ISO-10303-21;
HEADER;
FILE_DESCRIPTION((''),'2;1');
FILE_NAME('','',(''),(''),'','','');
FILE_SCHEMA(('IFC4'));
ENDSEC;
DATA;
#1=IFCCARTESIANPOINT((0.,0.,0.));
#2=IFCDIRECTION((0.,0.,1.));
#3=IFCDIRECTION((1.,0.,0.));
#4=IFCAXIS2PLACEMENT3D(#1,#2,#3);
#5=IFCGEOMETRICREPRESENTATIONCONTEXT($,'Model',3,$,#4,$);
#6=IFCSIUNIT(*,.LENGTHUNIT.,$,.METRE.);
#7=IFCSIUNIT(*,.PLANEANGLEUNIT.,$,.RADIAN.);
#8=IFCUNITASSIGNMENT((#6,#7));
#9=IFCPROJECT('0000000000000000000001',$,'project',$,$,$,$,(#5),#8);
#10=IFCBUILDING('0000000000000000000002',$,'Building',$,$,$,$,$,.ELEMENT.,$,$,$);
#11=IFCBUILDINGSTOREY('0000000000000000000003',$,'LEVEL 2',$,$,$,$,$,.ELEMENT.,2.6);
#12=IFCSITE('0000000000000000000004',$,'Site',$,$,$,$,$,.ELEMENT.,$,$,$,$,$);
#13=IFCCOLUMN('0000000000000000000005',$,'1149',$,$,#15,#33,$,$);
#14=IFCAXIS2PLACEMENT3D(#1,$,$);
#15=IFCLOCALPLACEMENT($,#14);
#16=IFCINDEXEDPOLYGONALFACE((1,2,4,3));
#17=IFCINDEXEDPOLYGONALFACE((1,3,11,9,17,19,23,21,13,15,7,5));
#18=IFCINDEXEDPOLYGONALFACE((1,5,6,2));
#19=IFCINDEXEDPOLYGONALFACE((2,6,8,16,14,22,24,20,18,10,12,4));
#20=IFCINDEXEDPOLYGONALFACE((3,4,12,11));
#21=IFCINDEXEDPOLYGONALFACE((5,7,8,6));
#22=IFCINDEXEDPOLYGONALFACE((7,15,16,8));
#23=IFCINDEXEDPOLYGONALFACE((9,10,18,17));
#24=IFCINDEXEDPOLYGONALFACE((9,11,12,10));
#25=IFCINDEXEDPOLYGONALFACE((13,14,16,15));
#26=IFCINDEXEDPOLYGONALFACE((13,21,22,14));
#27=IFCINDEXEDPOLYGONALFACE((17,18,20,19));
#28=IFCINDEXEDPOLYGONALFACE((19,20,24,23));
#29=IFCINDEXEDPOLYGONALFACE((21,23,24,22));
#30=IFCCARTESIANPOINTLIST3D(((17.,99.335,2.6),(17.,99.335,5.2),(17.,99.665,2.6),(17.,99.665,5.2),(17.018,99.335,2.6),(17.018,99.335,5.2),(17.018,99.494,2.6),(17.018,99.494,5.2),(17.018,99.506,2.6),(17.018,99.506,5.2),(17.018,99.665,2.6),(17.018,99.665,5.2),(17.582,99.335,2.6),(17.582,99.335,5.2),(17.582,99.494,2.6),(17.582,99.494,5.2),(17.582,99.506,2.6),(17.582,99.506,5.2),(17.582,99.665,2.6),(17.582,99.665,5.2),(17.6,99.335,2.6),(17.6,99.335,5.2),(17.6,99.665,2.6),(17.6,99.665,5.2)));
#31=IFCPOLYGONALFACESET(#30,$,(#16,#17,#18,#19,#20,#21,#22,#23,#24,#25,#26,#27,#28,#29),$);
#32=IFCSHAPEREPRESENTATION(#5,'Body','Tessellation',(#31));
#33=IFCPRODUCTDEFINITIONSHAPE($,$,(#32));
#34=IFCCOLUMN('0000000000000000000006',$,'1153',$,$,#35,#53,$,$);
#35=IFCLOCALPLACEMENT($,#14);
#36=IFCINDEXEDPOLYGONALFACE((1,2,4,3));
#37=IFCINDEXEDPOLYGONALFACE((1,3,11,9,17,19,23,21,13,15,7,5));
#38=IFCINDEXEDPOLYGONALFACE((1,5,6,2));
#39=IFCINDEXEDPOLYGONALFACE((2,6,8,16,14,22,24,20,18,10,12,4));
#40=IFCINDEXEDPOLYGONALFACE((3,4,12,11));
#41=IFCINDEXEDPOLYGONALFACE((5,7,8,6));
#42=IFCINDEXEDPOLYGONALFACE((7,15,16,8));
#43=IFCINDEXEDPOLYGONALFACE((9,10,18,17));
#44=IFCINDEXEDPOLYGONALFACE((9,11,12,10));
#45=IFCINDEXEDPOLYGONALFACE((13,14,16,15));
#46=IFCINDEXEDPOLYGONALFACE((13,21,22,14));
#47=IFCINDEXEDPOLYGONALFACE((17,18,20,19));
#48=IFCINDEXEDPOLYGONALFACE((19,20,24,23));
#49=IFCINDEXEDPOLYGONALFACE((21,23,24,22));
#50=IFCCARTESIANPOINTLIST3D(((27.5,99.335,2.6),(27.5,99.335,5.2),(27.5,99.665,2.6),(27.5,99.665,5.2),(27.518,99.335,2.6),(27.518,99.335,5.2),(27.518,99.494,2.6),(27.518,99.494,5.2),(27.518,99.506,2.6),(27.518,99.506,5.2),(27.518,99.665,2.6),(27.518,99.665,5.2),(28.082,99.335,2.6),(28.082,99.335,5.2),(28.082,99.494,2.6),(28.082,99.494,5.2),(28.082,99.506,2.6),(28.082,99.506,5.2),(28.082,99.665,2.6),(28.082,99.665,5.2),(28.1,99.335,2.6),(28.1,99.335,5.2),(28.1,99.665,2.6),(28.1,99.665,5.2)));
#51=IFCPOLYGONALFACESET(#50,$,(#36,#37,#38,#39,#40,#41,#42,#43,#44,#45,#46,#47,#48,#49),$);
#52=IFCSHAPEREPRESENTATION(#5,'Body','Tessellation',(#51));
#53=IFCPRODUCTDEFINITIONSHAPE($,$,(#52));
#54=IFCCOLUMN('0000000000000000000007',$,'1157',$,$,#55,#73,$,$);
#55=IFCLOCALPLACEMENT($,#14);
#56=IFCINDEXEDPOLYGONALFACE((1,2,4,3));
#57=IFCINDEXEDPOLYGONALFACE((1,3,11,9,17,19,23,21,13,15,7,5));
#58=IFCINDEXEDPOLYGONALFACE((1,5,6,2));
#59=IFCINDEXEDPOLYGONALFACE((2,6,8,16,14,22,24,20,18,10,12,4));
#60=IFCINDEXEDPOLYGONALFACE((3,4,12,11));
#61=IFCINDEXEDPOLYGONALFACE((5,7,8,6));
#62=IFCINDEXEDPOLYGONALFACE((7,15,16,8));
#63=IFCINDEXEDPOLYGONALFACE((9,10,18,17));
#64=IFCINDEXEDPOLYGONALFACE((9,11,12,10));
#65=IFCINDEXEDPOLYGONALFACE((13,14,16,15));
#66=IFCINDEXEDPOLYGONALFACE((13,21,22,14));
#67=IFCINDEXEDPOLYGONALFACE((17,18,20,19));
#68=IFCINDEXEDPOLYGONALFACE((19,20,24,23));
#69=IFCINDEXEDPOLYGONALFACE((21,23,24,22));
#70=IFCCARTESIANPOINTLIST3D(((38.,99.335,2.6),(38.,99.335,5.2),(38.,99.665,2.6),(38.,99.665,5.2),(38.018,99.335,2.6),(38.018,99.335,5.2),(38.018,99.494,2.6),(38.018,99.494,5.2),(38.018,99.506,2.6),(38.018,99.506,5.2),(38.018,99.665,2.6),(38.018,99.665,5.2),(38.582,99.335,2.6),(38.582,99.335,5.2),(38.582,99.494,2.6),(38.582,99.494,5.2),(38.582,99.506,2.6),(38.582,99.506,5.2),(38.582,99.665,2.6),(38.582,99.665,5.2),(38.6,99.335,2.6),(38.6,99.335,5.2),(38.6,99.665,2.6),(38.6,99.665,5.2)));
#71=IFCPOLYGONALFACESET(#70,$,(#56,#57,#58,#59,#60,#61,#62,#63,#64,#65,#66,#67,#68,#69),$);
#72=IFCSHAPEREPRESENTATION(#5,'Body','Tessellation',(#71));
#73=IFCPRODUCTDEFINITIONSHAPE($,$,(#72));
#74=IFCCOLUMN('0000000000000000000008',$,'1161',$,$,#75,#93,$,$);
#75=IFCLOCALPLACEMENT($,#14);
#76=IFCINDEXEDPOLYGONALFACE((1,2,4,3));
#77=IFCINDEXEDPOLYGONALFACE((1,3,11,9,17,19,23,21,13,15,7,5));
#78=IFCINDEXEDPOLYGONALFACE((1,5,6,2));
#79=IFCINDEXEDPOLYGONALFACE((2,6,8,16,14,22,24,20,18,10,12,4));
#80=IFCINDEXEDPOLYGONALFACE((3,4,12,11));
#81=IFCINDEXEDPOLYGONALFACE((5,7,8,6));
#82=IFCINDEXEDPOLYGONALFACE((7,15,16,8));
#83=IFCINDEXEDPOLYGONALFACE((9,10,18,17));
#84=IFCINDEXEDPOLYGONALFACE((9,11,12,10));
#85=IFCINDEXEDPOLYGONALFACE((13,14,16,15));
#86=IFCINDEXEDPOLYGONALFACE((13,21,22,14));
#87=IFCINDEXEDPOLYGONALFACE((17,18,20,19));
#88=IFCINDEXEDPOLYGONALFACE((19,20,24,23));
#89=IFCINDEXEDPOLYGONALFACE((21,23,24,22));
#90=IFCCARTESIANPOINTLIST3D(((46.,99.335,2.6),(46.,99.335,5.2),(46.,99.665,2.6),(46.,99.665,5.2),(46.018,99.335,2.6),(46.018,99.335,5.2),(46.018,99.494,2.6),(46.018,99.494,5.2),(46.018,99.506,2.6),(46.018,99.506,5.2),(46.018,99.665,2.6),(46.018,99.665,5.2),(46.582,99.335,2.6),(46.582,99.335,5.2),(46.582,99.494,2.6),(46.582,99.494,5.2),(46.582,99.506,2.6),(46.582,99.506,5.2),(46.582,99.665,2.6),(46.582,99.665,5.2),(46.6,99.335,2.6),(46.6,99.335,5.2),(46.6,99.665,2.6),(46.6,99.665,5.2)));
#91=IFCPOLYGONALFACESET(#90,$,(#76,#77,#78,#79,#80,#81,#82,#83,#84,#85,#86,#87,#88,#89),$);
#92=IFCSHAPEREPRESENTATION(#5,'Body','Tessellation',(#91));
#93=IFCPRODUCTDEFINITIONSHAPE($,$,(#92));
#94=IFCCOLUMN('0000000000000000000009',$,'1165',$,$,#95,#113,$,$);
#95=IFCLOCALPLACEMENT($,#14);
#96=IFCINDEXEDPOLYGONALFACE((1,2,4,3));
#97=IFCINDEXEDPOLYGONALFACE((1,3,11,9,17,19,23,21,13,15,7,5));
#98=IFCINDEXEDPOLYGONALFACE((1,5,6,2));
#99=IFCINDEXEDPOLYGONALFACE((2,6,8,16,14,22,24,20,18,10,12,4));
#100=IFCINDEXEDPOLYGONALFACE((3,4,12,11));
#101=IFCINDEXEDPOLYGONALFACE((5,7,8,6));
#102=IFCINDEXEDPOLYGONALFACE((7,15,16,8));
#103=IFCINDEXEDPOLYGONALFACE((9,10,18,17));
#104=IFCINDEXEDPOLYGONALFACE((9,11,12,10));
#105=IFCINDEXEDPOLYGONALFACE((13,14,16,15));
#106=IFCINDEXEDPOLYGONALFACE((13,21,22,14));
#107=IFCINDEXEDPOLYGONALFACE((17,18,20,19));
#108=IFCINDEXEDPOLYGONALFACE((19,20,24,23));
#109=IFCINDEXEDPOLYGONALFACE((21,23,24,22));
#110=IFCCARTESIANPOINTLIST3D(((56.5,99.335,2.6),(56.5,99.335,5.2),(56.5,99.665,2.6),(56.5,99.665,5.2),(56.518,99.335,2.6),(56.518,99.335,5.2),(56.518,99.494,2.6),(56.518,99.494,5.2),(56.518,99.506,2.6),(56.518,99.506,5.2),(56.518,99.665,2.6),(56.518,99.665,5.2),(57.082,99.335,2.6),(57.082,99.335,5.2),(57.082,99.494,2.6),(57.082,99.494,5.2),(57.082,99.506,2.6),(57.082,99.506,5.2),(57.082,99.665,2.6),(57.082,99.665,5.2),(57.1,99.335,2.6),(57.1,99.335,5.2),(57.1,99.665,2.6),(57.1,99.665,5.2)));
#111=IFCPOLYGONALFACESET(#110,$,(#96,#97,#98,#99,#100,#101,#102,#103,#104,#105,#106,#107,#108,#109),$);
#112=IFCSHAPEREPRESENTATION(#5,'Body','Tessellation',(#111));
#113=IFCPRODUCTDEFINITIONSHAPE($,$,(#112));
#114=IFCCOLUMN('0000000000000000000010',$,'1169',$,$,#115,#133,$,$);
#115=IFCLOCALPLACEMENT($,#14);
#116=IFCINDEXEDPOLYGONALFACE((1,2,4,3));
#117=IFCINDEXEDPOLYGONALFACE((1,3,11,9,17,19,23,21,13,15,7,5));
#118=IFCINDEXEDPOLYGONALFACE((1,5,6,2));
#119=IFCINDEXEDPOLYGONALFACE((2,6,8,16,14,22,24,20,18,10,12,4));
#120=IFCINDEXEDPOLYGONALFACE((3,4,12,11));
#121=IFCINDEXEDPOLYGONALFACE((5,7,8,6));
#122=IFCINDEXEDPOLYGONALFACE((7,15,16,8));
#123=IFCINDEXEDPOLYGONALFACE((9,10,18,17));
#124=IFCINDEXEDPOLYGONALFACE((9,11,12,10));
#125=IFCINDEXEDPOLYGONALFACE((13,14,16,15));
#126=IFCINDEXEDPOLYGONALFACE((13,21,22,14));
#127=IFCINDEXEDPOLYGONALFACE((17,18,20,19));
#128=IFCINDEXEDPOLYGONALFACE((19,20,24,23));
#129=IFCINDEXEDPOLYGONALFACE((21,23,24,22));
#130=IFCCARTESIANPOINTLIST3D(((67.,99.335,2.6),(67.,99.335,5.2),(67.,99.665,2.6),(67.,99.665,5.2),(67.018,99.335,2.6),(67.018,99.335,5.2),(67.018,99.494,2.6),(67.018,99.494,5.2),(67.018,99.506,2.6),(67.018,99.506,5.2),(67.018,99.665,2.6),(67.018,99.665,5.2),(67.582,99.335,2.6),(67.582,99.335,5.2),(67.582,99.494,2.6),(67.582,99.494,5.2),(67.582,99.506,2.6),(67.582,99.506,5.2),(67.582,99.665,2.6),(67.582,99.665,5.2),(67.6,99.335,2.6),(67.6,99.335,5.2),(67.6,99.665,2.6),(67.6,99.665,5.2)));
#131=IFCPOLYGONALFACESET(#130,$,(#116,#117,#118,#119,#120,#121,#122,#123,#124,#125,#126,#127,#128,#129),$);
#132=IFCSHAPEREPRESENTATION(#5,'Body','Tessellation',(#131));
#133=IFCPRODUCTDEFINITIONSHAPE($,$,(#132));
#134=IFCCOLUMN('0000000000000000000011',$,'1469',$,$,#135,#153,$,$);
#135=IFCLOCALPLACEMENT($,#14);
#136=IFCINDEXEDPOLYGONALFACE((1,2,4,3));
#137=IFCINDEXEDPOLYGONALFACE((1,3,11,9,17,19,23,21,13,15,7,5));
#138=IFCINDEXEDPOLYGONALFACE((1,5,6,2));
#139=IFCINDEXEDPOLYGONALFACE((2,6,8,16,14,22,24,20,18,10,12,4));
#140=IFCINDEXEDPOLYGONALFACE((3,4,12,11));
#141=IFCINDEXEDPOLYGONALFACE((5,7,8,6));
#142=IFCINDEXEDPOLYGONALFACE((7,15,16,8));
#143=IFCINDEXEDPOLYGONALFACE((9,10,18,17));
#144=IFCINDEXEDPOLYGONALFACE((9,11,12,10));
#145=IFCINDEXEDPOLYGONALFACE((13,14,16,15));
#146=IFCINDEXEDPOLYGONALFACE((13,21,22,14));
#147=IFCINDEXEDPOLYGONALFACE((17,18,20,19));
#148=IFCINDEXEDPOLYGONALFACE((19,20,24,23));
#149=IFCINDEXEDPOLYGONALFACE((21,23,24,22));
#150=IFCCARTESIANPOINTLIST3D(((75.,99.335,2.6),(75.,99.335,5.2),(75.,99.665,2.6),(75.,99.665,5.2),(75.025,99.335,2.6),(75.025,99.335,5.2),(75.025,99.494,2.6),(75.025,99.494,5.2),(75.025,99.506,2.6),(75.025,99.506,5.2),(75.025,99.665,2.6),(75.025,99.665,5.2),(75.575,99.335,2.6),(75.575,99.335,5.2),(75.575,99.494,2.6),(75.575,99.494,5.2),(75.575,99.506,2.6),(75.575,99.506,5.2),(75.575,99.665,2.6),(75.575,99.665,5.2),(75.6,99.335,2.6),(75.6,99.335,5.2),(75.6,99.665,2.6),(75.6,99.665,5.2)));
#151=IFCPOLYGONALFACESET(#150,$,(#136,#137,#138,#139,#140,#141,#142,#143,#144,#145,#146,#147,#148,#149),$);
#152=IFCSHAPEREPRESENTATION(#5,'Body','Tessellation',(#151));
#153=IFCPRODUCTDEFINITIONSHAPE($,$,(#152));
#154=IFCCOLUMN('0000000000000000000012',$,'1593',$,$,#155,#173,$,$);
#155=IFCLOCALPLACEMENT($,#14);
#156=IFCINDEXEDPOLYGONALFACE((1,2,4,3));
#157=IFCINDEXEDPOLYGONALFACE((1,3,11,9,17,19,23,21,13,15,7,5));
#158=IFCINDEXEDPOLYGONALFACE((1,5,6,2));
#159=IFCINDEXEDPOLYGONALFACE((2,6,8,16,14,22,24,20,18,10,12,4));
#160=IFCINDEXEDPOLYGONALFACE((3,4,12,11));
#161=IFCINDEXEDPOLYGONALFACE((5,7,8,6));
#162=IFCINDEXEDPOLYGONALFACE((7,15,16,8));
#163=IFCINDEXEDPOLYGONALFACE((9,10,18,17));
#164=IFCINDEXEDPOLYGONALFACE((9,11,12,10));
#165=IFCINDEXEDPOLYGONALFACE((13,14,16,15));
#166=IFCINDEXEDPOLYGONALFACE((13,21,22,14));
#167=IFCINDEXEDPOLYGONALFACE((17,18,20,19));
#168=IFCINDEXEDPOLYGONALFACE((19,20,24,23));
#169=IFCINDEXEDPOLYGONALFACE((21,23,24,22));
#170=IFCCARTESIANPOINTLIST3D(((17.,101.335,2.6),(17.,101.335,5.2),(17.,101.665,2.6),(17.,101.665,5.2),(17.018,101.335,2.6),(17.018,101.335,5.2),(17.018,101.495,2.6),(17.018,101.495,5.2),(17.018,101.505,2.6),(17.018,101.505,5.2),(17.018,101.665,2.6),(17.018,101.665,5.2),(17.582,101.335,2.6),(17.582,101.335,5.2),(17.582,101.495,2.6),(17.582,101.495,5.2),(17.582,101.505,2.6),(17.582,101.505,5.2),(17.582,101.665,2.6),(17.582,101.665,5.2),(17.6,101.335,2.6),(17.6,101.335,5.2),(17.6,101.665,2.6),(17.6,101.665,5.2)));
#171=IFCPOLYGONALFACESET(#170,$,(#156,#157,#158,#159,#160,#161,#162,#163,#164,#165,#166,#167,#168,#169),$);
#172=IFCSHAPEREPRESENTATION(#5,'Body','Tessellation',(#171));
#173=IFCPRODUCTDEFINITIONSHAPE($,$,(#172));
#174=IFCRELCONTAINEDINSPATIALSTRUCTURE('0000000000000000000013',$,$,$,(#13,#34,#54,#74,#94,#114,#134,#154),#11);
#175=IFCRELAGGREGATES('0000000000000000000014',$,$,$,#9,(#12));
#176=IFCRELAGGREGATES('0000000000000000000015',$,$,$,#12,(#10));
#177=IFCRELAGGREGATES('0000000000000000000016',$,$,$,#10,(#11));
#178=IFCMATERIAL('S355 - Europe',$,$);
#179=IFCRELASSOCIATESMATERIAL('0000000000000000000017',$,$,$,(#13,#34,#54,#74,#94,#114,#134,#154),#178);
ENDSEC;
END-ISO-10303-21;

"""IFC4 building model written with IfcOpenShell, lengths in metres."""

from ifc_helpers import new_model, si_unit, frame, origin_with_axes, origin_2d_with_axis, place, context, project, spatial, i_section, extrude, material, material_profile, profile_set, profile_usage, element, save


model = new_model("IFC4")

# Units and contexts
model_context = context("Model", 3, world=origin_with_axes())
ifc_project = project(units=[si_unit("LENGTHUNIT", "METRE"), si_unit("PLANEANGLEUNIT", "RADIAN")], contexts=[model_context])

# Site, building, storey
site = spatial("IfcSite", under=ifc_project, Name="Site", CompositionType="ELEMENT")
building = spatial("IfcBuilding", under=site, Name="Building", CompositionType="ELEMENT")
storey = spatial("IfcBuildingStorey", under=building, Name="LEVEL 2", CompositionType="ELEMENT", Elevation=2.6)

# Columns
ifc_material = material(Name="S355 - Europe")
ifc_material_profile_1 = material_profile(ifc_material, i_section(OverallWidth=0.33, OverallDepth=0.6, WebThickness=0.012, FlangeThickness=0.018, at=origin_2d_with_axis()))
ifc_profile_set_1 = profile_set([ifc_material_profile_1])
ifc_profile_usage_1 = profile_usage(ifc_profile_set_1, cardinal=10)
column_1_placement = place(None, frame((17.3, 99.5, 2.6), z_axis=(0.0, 0.0, 1.0), x_axis=(0.0, -1.0, 0.0)))
element("IfcColumn", 1, at=column_1_placement, inside=storey, material=ifc_profile_usage_1, Name="1149", context=model_context, shape_type="SweptSolid", body=[
    extrude(i_section(OverallWidth=0.33, OverallDepth=0.6, WebThickness=0.012, FlangeThickness=0.018, at=origin_2d_with_axis()), origin_with_axes(), (0.0, 0.0, 1.0), 2.6),
])
ifc_material_profile_2 = material_profile(ifc_material, i_section(OverallWidth=0.33, OverallDepth=0.6, WebThickness=0.012, FlangeThickness=0.018, at=origin_2d_with_axis()))
ifc_profile_set_2 = profile_set([ifc_material_profile_2])
ifc_profile_usage_2 = profile_usage(ifc_profile_set_2, cardinal=10)
column_2_placement = place(None, frame((27.8, 99.5, 2.6), z_axis=(0.0, 0.0, 1.0), x_axis=(0.0, -1.0, 0.0)))
element("IfcColumn", 2, at=column_2_placement, inside=storey, material=ifc_profile_usage_2, Name="1153", context=model_context, shape_type="SweptSolid", body=[
    extrude(i_section(OverallWidth=0.33, OverallDepth=0.6, WebThickness=0.012, FlangeThickness=0.018, at=origin_2d_with_axis()), origin_with_axes(), (0.0, 0.0, 1.0), 2.6),
])
ifc_material_profile_3 = material_profile(ifc_material, i_section(OverallWidth=0.33, OverallDepth=0.6, WebThickness=0.012, FlangeThickness=0.018, at=origin_2d_with_axis()))
ifc_profile_set_3 = profile_set([ifc_material_profile_3])
ifc_profile_usage_3 = profile_usage(ifc_profile_set_3, cardinal=10)
column_3_placement = place(None, frame((38.3, 99.5, 2.6), z_axis=(0.0, 0.0, 1.0), x_axis=(0.0, -1.0, 0.0)))
element("IfcColumn", 3, at=column_3_placement, inside=storey, material=ifc_profile_usage_3, Name="1157", context=model_context, shape_type="SweptSolid", body=[
    extrude(i_section(OverallWidth=0.33, OverallDepth=0.6, WebThickness=0.012, FlangeThickness=0.018, at=origin_2d_with_axis()), origin_with_axes(), (0.0, 0.0, 1.0), 2.6),
])
ifc_material_profile_4 = material_profile(ifc_material, i_section(OverallWidth=0.33, OverallDepth=0.6, WebThickness=0.012, FlangeThickness=0.018, at=origin_2d_with_axis()))
ifc_profile_set_4 = profile_set([ifc_material_profile_4])
ifc_profile_usage_4 = profile_usage(ifc_profile_set_4, cardinal=10)
column_4_placement = place(None, frame((46.3, 99.5, 2.6), z_axis=(0.0, 0.0, 1.0), x_axis=(0.0, -1.0, 0.0)))
element("IfcColumn", 4, at=column_4_placement, inside=storey, material=ifc_profile_usage_4, Name="1161", context=model_context, shape_type="SweptSolid", body=[
    extrude(i_section(OverallWidth=0.33, OverallDepth=0.6, WebThickness=0.012, FlangeThickness=0.018, at=origin_2d_with_axis()), origin_with_axes(), (0.0, 0.0, 1.0), 2.6),
])
ifc_material_profile_5 = material_profile(ifc_material, i_section(OverallWidth=0.33, OverallDepth=0.6, WebThickness=0.012, FlangeThickness=0.018, at=origin_2d_with_axis()))
ifc_profile_set_5 = profile_set([ifc_material_profile_5])
ifc_profile_usage_5 = profile_usage(ifc_profile_set_5, cardinal=10)
column_5_placement = place(None, frame((56.8, 99.5, 2.6), z_axis=(0.0, 0.0, 1.0), x_axis=(0.0, -1.0, 0.0)))
element("IfcColumn", 5, at=column_5_placement, inside=storey, material=ifc_profile_usage_5, Name="1165", context=model_context, shape_type="SweptSolid", body=[
    extrude(i_section(OverallWidth=0.33, OverallDepth=0.6, WebThickness=0.012, FlangeThickness=0.018, at=origin_2d_with_axis()), origin_with_axes(), (0.0, 0.0, 1.0), 2.6),
])
ifc_material_profile_6 = material_profile(ifc_material, i_section(OverallWidth=0.33, OverallDepth=0.6, WebThickness=0.012, FlangeThickness=0.018, at=origin_2d_with_axis()))
ifc_profile_set_6 = profile_set([ifc_material_profile_6])
ifc_profile_usage_6 = profile_usage(ifc_profile_set_6, cardinal=10)
column_6_placement = place(None, frame((67.3, 99.5, 2.6), z_axis=(0.0, 0.0, 1.0), x_axis=(0.0, -1.0, 0.0)))
element("IfcColumn", 6, at=column_6_placement, inside=storey, material=ifc_profile_usage_6, Name="1169", context=model_context, shape_type="SweptSolid", body=[
    extrude(i_section(OverallWidth=0.33, OverallDepth=0.6, WebThickness=0.012, FlangeThickness=0.018, at=origin_2d_with_axis()), origin_with_axes(), (0.0, 0.0, 1.0), 2.6),
])
ifc_material_profile_7 = material_profile(ifc_material, i_section(OverallWidth=0.33, OverallDepth=0.6, WebThickness=0.012, FlangeThickness=0.025, at=origin_2d_with_axis()))
ifc_profile_set_7 = profile_set([ifc_material_profile_7])
ifc_profile_usage_7 = profile_usage(ifc_profile_set_7, cardinal=10)
column_7_placement = place(None, frame((75.3, 99.5, 2.6), z_axis=(0.0, 0.0, 1.0), x_axis=(0.0, -1.0, 0.0)))
element("IfcColumn", 7, at=column_7_placement, inside=storey, material=ifc_profile_usage_7, Name="1469", context=model_context, shape_type="SweptSolid", body=[
    extrude(i_section(OverallWidth=0.33, OverallDepth=0.6, WebThickness=0.012, FlangeThickness=0.025, at=origin_2d_with_axis()), origin_with_axes(), (0.0, 0.0, 1.0), 2.6),
])
ifc_material_profile_8 = material_profile(ifc_material, i_section(OverallWidth=0.33, OverallDepth=0.6, WebThickness=0.01, FlangeThickness=0.018, at=origin_2d_with_axis()))
ifc_profile_set_8 = profile_set([ifc_material_profile_8])
ifc_profile_usage_8 = profile_usage(ifc_profile_set_8, cardinal=10)
column_8_placement = place(None, frame((17.3, 101.5, 2.6), z_axis=(0.0, 0.0, 1.0), x_axis=(0.0, -1.0, 0.0)))
element("IfcColumn", 8, at=column_8_placement, inside=storey, material=ifc_profile_usage_8, Name="1593", context=model_context, shape_type="SweptSolid", body=[
    extrude(i_section(OverallWidth=0.33, OverallDepth=0.6, WebThickness=0.01, FlangeThickness=0.018, at=origin_2d_with_axis()), origin_with_axes(), (0.0, 0.0, 1.0), 2.6),
])

save(model, "model.ifc")
